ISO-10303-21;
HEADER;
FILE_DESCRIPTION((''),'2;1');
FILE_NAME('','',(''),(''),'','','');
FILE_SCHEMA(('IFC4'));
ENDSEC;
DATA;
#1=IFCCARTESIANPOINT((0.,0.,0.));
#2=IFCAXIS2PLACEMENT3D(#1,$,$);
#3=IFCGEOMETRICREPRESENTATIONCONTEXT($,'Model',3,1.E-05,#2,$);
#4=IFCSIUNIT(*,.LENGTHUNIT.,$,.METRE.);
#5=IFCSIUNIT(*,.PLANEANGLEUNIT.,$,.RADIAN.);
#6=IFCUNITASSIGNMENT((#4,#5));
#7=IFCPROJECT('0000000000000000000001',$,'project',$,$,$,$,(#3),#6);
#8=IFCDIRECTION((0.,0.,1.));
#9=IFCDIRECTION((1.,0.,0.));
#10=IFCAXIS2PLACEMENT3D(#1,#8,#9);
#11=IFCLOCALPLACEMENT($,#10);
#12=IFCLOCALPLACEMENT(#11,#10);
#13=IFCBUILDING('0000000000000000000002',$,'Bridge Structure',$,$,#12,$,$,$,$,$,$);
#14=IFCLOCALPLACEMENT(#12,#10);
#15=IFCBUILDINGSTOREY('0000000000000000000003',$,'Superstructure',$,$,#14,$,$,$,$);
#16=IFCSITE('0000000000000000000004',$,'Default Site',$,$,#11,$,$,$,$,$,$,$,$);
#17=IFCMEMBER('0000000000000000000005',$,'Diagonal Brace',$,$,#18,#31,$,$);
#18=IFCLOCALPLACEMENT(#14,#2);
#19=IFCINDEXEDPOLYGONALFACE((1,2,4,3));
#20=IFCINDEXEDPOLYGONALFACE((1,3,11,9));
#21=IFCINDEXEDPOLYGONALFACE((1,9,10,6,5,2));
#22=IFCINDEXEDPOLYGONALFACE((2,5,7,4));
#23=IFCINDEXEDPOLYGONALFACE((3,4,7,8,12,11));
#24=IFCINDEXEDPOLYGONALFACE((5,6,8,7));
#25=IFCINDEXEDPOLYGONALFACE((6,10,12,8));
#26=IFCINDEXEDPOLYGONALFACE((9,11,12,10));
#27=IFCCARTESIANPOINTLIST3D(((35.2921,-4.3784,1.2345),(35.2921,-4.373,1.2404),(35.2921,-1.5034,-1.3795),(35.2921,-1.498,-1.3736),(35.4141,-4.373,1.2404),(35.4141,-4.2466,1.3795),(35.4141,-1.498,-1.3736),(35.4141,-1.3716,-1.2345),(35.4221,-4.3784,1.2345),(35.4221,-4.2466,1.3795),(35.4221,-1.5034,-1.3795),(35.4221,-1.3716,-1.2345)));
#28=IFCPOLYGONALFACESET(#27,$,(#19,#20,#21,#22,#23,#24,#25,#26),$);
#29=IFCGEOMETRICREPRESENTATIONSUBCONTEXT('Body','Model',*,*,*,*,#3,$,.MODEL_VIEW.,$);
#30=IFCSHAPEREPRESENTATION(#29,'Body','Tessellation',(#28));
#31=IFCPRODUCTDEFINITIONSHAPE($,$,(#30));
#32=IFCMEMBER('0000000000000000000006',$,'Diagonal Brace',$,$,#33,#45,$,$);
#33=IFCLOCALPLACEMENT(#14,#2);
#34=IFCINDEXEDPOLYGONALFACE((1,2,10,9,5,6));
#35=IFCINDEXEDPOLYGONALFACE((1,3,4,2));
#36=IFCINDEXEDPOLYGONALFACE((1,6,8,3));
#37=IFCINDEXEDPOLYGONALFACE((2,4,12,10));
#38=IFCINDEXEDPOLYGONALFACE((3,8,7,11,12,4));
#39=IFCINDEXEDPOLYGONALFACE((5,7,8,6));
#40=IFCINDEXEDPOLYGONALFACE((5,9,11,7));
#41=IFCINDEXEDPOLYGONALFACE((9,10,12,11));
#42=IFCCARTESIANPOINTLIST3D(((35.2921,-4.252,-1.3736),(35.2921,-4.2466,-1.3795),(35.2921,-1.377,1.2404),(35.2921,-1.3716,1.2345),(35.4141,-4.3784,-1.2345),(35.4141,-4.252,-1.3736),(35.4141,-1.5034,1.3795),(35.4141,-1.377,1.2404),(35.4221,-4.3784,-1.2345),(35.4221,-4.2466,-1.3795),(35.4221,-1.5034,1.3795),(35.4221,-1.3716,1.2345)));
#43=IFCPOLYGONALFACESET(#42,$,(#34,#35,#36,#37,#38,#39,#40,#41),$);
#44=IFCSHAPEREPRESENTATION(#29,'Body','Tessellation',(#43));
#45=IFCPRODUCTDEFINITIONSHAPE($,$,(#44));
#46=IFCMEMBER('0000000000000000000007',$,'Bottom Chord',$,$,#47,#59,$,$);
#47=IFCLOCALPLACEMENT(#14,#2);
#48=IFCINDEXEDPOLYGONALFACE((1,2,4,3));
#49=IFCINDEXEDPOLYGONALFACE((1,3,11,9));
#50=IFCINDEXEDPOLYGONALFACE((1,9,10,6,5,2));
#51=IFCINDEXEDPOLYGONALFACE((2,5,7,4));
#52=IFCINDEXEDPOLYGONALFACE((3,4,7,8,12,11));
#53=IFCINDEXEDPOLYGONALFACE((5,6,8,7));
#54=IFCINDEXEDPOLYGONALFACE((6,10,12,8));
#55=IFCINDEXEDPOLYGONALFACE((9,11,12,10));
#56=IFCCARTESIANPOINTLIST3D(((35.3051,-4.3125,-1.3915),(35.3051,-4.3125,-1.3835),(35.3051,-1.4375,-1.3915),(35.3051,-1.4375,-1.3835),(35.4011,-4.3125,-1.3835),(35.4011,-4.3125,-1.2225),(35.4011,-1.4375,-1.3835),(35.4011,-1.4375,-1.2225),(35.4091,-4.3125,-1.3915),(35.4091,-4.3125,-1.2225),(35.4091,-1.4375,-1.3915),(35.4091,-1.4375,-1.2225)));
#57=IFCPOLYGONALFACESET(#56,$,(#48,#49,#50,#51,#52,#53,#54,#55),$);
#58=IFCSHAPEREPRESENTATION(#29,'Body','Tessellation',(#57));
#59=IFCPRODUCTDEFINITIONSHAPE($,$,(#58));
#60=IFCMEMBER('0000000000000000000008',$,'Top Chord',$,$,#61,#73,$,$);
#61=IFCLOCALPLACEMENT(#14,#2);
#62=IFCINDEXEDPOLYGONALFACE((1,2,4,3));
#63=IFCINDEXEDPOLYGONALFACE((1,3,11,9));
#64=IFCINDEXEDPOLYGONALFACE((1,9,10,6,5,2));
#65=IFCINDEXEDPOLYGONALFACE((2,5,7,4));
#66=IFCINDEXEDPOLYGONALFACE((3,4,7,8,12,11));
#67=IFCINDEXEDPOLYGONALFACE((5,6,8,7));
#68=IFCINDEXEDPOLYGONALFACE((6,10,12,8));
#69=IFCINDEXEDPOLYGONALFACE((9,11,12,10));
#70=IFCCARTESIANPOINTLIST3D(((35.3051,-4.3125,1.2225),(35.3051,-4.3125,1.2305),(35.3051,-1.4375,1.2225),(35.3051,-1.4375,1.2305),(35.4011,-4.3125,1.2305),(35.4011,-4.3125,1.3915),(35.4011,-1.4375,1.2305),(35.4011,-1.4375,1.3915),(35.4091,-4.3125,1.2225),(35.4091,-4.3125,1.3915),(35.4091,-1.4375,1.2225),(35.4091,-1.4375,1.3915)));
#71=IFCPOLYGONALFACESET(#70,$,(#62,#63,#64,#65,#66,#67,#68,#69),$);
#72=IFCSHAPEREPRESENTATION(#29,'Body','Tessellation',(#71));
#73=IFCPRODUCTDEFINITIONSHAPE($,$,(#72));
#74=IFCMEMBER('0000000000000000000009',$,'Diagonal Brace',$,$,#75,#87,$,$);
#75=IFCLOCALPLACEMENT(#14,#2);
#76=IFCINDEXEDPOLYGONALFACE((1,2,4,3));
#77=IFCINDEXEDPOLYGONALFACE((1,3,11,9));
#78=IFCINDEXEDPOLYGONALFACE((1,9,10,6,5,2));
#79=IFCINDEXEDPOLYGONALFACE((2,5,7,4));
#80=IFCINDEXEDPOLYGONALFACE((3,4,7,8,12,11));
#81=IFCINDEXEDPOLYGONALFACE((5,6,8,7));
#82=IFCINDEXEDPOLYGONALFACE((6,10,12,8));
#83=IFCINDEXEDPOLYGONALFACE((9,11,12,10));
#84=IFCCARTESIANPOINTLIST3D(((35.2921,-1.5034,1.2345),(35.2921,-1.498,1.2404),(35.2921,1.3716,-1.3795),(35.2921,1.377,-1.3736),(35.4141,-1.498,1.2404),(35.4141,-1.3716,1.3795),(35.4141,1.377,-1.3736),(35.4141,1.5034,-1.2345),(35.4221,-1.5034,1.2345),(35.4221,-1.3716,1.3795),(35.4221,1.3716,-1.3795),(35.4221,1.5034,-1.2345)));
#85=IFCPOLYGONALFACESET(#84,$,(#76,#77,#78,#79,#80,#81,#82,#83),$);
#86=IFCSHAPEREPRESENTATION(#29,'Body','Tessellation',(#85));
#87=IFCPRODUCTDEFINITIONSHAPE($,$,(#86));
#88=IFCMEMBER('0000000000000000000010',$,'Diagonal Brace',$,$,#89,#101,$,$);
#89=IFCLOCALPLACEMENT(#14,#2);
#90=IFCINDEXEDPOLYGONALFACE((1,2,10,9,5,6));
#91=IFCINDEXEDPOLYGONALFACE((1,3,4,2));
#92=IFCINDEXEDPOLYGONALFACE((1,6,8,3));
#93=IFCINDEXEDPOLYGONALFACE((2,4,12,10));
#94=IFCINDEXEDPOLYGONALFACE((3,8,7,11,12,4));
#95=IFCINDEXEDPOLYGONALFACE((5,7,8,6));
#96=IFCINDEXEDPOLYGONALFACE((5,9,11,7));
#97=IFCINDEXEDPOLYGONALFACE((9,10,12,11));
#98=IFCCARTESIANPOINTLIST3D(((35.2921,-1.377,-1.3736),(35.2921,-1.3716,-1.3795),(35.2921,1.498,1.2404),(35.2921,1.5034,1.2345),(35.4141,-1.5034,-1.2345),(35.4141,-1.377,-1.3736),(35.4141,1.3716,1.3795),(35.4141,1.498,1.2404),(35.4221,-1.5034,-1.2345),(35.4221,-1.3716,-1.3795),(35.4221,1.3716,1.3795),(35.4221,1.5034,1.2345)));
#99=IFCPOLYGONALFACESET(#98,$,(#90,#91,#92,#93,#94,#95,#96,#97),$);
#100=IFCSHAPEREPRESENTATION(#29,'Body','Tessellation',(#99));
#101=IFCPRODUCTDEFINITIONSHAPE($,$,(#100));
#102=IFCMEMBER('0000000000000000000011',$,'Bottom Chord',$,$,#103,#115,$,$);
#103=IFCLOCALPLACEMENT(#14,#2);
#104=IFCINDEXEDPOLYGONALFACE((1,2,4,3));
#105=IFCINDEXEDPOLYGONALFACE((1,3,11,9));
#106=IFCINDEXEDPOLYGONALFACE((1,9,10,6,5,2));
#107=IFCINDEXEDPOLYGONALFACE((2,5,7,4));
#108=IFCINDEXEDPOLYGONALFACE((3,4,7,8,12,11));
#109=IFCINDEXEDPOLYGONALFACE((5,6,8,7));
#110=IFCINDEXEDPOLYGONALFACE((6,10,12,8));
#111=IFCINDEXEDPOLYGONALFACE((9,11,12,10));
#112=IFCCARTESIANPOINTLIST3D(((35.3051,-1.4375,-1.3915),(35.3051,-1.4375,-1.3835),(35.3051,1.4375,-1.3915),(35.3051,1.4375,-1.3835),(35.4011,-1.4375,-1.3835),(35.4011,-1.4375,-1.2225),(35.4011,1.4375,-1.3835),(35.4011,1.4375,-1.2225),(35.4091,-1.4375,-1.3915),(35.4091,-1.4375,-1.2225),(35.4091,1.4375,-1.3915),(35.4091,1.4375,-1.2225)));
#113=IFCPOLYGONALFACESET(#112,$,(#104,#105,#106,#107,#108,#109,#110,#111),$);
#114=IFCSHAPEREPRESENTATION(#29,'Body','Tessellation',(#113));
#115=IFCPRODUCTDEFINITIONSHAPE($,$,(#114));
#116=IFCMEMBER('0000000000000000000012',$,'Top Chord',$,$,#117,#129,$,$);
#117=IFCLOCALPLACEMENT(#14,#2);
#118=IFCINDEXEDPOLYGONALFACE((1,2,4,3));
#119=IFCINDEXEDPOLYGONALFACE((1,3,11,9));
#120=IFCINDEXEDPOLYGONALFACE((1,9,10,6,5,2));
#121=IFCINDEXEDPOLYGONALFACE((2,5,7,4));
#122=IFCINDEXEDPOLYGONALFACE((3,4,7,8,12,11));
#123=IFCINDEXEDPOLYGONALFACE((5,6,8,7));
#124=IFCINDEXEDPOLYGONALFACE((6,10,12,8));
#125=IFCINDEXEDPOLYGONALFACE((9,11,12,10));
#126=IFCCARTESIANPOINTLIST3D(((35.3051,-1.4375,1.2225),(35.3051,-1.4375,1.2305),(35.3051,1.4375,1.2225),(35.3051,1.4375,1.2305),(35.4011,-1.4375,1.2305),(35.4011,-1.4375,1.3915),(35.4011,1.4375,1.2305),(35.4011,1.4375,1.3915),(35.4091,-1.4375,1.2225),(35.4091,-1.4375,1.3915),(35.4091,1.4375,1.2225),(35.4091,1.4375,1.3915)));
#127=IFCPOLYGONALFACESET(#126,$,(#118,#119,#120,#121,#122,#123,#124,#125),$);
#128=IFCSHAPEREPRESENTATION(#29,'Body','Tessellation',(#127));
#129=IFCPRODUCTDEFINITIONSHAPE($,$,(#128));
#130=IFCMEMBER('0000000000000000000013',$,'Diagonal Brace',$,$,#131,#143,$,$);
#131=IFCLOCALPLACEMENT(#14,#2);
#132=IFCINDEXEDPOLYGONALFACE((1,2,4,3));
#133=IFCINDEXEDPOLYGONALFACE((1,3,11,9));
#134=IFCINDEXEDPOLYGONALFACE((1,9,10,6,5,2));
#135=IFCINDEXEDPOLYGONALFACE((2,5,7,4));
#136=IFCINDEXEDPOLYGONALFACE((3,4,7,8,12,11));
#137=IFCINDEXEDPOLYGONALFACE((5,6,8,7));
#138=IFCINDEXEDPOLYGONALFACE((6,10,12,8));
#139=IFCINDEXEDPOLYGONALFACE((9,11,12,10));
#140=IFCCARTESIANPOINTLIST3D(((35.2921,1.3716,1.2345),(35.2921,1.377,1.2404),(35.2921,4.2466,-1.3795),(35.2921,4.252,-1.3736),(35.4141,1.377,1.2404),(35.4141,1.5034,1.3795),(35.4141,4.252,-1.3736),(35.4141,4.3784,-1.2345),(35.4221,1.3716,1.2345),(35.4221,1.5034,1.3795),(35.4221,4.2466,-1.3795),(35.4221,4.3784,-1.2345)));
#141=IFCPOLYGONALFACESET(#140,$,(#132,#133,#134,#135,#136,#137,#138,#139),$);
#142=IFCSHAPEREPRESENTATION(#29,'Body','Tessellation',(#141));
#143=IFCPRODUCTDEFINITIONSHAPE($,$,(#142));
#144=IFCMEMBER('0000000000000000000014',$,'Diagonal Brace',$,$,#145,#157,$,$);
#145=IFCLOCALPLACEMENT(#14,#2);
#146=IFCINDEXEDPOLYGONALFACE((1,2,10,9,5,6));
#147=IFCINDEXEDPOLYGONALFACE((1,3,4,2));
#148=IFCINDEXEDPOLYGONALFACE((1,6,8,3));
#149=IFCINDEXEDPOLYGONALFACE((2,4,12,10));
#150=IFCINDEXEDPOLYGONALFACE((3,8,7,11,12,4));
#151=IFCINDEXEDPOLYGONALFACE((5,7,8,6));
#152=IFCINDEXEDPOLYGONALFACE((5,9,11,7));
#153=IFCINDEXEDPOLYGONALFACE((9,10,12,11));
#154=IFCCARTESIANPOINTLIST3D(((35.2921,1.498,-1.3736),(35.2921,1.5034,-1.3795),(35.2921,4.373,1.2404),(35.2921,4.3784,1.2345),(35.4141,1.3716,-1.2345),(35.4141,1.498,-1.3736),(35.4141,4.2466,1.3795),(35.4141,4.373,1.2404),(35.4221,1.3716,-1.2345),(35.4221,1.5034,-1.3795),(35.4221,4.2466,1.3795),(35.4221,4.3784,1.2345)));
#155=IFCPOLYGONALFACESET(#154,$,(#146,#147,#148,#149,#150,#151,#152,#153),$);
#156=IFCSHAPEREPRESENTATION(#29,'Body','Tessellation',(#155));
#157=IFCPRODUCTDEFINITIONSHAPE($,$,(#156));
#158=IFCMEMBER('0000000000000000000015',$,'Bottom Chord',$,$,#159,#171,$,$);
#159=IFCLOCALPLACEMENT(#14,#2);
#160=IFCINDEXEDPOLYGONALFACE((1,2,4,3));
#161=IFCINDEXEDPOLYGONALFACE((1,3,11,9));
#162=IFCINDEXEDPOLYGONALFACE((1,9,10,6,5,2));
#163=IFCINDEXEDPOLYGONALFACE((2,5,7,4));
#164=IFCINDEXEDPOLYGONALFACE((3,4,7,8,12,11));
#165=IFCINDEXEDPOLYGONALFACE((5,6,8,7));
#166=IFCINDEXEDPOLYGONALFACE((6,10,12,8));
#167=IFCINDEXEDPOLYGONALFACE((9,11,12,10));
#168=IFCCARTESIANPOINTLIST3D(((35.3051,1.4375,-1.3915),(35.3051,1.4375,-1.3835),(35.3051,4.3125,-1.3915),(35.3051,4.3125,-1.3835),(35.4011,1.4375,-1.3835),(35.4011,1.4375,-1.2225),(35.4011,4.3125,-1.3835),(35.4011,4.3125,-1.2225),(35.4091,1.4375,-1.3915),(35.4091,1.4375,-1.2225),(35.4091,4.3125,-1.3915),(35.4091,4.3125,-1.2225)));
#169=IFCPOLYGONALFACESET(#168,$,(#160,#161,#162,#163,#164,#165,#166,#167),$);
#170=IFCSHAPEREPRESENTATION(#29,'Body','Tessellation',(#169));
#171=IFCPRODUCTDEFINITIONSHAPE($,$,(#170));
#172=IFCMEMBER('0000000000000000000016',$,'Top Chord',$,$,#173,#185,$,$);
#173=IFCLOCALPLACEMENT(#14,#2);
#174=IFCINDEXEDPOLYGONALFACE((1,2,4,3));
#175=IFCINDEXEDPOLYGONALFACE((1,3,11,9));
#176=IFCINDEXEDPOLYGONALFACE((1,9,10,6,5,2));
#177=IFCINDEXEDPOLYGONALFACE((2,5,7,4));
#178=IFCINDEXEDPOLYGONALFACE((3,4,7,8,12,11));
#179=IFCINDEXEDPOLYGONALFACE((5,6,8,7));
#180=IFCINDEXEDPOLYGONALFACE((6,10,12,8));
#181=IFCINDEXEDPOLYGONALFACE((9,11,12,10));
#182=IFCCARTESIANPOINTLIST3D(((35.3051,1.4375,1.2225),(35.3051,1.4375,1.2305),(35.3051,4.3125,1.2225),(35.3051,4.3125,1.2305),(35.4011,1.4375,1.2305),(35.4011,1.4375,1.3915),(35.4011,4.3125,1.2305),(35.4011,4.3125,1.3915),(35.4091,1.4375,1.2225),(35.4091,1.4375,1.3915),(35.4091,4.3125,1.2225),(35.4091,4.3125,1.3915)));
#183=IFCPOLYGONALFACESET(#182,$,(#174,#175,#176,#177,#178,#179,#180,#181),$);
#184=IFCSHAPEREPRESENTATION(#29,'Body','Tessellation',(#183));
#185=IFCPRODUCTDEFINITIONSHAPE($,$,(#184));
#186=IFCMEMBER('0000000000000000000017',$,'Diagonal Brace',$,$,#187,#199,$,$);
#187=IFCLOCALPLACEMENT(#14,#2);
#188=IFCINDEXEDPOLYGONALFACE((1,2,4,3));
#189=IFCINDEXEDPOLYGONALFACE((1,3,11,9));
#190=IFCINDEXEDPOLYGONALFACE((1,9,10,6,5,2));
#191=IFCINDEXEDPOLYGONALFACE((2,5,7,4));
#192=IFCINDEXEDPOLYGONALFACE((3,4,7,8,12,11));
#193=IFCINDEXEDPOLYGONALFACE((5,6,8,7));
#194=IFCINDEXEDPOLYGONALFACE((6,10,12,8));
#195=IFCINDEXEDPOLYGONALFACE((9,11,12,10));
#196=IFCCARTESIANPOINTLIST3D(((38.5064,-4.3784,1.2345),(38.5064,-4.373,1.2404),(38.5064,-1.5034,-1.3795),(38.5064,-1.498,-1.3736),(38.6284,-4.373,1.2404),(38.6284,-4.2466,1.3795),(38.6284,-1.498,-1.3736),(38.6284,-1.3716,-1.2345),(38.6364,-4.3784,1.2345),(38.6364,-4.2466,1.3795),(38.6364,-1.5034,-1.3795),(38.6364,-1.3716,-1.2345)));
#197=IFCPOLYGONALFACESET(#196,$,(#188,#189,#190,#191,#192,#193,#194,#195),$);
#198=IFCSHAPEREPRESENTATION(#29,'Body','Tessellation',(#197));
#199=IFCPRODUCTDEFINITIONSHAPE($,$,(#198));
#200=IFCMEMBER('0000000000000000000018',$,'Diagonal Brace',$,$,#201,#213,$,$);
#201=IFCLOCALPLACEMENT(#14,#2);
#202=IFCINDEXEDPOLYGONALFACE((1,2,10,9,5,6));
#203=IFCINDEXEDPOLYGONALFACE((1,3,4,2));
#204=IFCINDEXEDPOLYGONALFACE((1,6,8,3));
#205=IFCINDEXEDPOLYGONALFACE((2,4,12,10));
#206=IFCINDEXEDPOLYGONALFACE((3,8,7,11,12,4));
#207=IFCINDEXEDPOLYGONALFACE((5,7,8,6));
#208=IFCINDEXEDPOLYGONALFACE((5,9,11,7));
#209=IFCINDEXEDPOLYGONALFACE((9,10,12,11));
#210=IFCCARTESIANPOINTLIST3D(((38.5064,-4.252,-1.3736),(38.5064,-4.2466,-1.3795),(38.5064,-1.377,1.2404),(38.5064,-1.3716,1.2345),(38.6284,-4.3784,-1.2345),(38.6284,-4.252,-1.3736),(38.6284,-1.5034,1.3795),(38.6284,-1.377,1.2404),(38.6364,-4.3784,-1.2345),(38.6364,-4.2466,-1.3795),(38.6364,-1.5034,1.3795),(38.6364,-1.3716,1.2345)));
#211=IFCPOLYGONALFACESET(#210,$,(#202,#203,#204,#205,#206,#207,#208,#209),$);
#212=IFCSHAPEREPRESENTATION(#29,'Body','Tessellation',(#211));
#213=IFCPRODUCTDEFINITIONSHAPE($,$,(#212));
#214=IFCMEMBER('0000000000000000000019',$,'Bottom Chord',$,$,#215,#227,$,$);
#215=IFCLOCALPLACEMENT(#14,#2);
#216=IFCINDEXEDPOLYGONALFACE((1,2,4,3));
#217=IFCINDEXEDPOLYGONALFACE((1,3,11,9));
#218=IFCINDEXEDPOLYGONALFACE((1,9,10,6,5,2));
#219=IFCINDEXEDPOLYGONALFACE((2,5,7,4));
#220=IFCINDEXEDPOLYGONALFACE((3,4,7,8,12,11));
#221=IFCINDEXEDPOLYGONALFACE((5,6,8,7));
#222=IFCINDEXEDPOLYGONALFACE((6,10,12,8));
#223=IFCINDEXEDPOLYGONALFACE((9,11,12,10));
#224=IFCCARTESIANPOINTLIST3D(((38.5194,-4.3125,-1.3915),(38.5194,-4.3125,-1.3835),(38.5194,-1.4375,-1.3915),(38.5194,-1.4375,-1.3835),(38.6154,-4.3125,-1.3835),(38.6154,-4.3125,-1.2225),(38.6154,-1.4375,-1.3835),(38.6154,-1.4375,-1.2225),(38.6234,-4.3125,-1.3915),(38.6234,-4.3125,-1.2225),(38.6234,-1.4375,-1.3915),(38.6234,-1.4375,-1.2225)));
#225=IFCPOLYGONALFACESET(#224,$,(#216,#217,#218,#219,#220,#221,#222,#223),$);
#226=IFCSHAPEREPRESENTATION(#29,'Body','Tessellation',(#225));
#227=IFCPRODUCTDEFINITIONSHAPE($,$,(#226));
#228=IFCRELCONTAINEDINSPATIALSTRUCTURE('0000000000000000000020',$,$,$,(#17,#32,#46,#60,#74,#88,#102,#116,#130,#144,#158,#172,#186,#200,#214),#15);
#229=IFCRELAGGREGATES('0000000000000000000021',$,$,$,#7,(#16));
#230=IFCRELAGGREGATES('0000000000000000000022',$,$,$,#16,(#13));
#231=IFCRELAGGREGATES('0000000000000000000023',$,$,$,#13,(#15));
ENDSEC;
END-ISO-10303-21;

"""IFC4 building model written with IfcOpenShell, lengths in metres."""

from ifc_helpers import new_model, si_unit, frame, origin, origin_with_axes, origin_2d_with_axis, place, context, subcontext, project, spatial, l_section, extrude, element, save


model = new_model("IFC4")

# Units and contexts
model_context = context("Model", 3, precision=1e-05, world=origin())
body_context = subcontext(model_context, "Body", "Model", "MODEL_VIEW")
ifc_project = project(units=[si_unit("LENGTHUNIT", "METRE"), si_unit("PLANEANGLEUNIT", "RADIAN")], contexts=[model_context])

# Site, building, storey
site_placement = place(None, origin_with_axes())
site = spatial("IfcSite", under=ifc_project, at=site_placement, Name="Default Site")
building_placement = place(site_placement, origin_with_axes())
building = spatial("IfcBuilding", under=site, at=building_placement, Name="Bridge Structure")
storey_placement = place(building_placement, origin_with_axes())
storey = spatial("IfcBuildingStorey", under=building, at=storey_placement, Name="Superstructure")

# Members
for number, where, z_axis, x_axis, name in (
    (1, (35.3571, -4.3125, 1.307), (0.0, 0.739893, -0.672724), (-1.0, 0.0, 0.0), "Diagonal Brace"),
    (2, (35.3571, -4.3125, -1.307), (0.0, 0.739893, 0.672724), (-1.0, 0.0, 0.0), "Diagonal Brace"),
):
    element("IfcMember", number, at=place(storey_placement, frame(where, z_axis=z_axis, x_axis=x_axis)), inside=storey, Name=name, context=body_context, shape_type="SweptSolid", body=[
        extrude(l_section(Depth=0.196, Width=0.13, Thickness=0.008, at=origin_2d_with_axis()), origin_with_axes(), (0.0, 0.0, 1.0), 3.8857),
    ])
for number, where, z_axis, x_axis, name in (
    (3, (35.3571, -4.3125, -1.307), (0.0, 1.0, 0.0), (-1.0, 0.0, 0.0), "Bottom Chord"),
    (4, (35.3571, -4.3125, 1.307), (0.0, 1.0, 0.0), (-1.0, 0.0, 0.0), "Top Chord"),
):
    element("IfcMember", number, at=place(storey_placement, frame(where, z_axis=z_axis, x_axis=x_axis)), inside=storey, Name=name, context=body_context, shape_type="SweptSolid", body=[
        extrude(l_section(Depth=0.169, Width=0.104, Thickness=0.008, at=origin_2d_with_axis()), origin_with_axes(), (0.0, 0.0, 1.0), 2.875),
    ])
for number, where, z_axis, x_axis, name in (
    (5, (35.3571, -1.4375, 1.307), (0.0, 0.739893, -0.672724), (-1.0, 0.0, 0.0), "Diagonal Brace"),
    (6, (35.3571, -1.4375, -1.307), (0.0, 0.739893, 0.672724), (-1.0, 0.0, 0.0), "Diagonal Brace"),
):
    element("IfcMember", number, at=place(storey_placement, frame(where, z_axis=z_axis, x_axis=x_axis)), inside=storey, Name=name, context=body_context, shape_type="SweptSolid", body=[
        extrude(l_section(Depth=0.196, Width=0.13, Thickness=0.008, at=origin_2d_with_axis()), origin_with_axes(), (0.0, 0.0, 1.0), 3.8857),
    ])
for number, where, z_axis, x_axis, name in (
    (7, (35.3571, -1.4375, -1.307), (0.0, 1.0, 0.0), (-1.0, 0.0, 0.0), "Bottom Chord"),
    (8, (35.3571, -1.4375, 1.307), (0.0, 1.0, 0.0), (-1.0, 0.0, 0.0), "Top Chord"),
):
    element("IfcMember", number, at=place(storey_placement, frame(where, z_axis=z_axis, x_axis=x_axis)), inside=storey, Name=name, context=body_context, shape_type="SweptSolid", body=[
        extrude(l_section(Depth=0.169, Width=0.104, Thickness=0.008, at=origin_2d_with_axis()), origin_with_axes(), (0.0, 0.0, 1.0), 2.875),
    ])
for number, where, z_axis, x_axis, name in (
    (9, (35.3571, 1.4375, 1.307), (0.0, 0.739893, -0.672724), (-1.0, 0.0, 0.0), "Diagonal Brace"),
    (10, (35.3571, 1.4375, -1.307), (0.0, 0.739893, 0.672724), (-1.0, 0.0, 0.0), "Diagonal Brace"),
):
    element("IfcMember", number, at=place(storey_placement, frame(where, z_axis=z_axis, x_axis=x_axis)), inside=storey, Name=name, context=body_context, shape_type="SweptSolid", body=[
        extrude(l_section(Depth=0.196, Width=0.13, Thickness=0.008, at=origin_2d_with_axis()), origin_with_axes(), (0.0, 0.0, 1.0), 3.8857),
    ])
for number, where, z_axis, x_axis, name in (
    (11, (35.3571, 1.4375, -1.307), (0.0, 1.0, 0.0), (-1.0, 0.0, 0.0), "Bottom Chord"),
    (12, (35.3571, 1.4375, 1.307), (0.0, 1.0, 0.0), (-1.0, 0.0, 0.0), "Top Chord"),
):
    element("IfcMember", number, at=place(storey_placement, frame(where, z_axis=z_axis, x_axis=x_axis)), inside=storey, Name=name, context=body_context, shape_type="SweptSolid", body=[
        extrude(l_section(Depth=0.169, Width=0.104, Thickness=0.008, at=origin_2d_with_axis()), origin_with_axes(), (0.0, 0.0, 1.0), 2.875),
    ])
for number, where, z_axis, x_axis, name in (
    (13, (38.5714, -4.3125, 1.307), (0.0, 0.739893, -0.672724), (-1.0, 0.0, 0.0), "Diagonal Brace"),
    (14, (38.5714, -4.3125, -1.307), (0.0, 0.739893, 0.672724), (-1.0, 0.0, 0.0), "Diagonal Brace"),
):
    element("IfcMember", number, at=place(storey_placement, frame(where, z_axis=z_axis, x_axis=x_axis)), inside=storey, Name=name, context=body_context, shape_type="SweptSolid", body=[
        extrude(l_section(Depth=0.196, Width=0.13, Thickness=0.008, at=origin_2d_with_axis()), origin_with_axes(), (0.0, 0.0, 1.0), 3.8857),
    ])
for number, where, z_axis, x_axis, name in (
    (15, (38.5714, -4.3125, -1.307), (0.0, 1.0, 0.0), (-1.0, 0.0, 0.0), "Bottom Chord"),
):
    element("IfcMember", number, at=place(storey_placement, frame(where, z_axis=z_axis, x_axis=x_axis)), inside=storey, Name=name, context=body_context, shape_type="SweptSolid", body=[
        extrude(l_section(Depth=0.169, Width=0.104, Thickness=0.008, at=origin_2d_with_axis()), origin_with_axes(), (0.0, 0.0, 1.0), 2.875),
    ])

save(model, "model.ifc")
